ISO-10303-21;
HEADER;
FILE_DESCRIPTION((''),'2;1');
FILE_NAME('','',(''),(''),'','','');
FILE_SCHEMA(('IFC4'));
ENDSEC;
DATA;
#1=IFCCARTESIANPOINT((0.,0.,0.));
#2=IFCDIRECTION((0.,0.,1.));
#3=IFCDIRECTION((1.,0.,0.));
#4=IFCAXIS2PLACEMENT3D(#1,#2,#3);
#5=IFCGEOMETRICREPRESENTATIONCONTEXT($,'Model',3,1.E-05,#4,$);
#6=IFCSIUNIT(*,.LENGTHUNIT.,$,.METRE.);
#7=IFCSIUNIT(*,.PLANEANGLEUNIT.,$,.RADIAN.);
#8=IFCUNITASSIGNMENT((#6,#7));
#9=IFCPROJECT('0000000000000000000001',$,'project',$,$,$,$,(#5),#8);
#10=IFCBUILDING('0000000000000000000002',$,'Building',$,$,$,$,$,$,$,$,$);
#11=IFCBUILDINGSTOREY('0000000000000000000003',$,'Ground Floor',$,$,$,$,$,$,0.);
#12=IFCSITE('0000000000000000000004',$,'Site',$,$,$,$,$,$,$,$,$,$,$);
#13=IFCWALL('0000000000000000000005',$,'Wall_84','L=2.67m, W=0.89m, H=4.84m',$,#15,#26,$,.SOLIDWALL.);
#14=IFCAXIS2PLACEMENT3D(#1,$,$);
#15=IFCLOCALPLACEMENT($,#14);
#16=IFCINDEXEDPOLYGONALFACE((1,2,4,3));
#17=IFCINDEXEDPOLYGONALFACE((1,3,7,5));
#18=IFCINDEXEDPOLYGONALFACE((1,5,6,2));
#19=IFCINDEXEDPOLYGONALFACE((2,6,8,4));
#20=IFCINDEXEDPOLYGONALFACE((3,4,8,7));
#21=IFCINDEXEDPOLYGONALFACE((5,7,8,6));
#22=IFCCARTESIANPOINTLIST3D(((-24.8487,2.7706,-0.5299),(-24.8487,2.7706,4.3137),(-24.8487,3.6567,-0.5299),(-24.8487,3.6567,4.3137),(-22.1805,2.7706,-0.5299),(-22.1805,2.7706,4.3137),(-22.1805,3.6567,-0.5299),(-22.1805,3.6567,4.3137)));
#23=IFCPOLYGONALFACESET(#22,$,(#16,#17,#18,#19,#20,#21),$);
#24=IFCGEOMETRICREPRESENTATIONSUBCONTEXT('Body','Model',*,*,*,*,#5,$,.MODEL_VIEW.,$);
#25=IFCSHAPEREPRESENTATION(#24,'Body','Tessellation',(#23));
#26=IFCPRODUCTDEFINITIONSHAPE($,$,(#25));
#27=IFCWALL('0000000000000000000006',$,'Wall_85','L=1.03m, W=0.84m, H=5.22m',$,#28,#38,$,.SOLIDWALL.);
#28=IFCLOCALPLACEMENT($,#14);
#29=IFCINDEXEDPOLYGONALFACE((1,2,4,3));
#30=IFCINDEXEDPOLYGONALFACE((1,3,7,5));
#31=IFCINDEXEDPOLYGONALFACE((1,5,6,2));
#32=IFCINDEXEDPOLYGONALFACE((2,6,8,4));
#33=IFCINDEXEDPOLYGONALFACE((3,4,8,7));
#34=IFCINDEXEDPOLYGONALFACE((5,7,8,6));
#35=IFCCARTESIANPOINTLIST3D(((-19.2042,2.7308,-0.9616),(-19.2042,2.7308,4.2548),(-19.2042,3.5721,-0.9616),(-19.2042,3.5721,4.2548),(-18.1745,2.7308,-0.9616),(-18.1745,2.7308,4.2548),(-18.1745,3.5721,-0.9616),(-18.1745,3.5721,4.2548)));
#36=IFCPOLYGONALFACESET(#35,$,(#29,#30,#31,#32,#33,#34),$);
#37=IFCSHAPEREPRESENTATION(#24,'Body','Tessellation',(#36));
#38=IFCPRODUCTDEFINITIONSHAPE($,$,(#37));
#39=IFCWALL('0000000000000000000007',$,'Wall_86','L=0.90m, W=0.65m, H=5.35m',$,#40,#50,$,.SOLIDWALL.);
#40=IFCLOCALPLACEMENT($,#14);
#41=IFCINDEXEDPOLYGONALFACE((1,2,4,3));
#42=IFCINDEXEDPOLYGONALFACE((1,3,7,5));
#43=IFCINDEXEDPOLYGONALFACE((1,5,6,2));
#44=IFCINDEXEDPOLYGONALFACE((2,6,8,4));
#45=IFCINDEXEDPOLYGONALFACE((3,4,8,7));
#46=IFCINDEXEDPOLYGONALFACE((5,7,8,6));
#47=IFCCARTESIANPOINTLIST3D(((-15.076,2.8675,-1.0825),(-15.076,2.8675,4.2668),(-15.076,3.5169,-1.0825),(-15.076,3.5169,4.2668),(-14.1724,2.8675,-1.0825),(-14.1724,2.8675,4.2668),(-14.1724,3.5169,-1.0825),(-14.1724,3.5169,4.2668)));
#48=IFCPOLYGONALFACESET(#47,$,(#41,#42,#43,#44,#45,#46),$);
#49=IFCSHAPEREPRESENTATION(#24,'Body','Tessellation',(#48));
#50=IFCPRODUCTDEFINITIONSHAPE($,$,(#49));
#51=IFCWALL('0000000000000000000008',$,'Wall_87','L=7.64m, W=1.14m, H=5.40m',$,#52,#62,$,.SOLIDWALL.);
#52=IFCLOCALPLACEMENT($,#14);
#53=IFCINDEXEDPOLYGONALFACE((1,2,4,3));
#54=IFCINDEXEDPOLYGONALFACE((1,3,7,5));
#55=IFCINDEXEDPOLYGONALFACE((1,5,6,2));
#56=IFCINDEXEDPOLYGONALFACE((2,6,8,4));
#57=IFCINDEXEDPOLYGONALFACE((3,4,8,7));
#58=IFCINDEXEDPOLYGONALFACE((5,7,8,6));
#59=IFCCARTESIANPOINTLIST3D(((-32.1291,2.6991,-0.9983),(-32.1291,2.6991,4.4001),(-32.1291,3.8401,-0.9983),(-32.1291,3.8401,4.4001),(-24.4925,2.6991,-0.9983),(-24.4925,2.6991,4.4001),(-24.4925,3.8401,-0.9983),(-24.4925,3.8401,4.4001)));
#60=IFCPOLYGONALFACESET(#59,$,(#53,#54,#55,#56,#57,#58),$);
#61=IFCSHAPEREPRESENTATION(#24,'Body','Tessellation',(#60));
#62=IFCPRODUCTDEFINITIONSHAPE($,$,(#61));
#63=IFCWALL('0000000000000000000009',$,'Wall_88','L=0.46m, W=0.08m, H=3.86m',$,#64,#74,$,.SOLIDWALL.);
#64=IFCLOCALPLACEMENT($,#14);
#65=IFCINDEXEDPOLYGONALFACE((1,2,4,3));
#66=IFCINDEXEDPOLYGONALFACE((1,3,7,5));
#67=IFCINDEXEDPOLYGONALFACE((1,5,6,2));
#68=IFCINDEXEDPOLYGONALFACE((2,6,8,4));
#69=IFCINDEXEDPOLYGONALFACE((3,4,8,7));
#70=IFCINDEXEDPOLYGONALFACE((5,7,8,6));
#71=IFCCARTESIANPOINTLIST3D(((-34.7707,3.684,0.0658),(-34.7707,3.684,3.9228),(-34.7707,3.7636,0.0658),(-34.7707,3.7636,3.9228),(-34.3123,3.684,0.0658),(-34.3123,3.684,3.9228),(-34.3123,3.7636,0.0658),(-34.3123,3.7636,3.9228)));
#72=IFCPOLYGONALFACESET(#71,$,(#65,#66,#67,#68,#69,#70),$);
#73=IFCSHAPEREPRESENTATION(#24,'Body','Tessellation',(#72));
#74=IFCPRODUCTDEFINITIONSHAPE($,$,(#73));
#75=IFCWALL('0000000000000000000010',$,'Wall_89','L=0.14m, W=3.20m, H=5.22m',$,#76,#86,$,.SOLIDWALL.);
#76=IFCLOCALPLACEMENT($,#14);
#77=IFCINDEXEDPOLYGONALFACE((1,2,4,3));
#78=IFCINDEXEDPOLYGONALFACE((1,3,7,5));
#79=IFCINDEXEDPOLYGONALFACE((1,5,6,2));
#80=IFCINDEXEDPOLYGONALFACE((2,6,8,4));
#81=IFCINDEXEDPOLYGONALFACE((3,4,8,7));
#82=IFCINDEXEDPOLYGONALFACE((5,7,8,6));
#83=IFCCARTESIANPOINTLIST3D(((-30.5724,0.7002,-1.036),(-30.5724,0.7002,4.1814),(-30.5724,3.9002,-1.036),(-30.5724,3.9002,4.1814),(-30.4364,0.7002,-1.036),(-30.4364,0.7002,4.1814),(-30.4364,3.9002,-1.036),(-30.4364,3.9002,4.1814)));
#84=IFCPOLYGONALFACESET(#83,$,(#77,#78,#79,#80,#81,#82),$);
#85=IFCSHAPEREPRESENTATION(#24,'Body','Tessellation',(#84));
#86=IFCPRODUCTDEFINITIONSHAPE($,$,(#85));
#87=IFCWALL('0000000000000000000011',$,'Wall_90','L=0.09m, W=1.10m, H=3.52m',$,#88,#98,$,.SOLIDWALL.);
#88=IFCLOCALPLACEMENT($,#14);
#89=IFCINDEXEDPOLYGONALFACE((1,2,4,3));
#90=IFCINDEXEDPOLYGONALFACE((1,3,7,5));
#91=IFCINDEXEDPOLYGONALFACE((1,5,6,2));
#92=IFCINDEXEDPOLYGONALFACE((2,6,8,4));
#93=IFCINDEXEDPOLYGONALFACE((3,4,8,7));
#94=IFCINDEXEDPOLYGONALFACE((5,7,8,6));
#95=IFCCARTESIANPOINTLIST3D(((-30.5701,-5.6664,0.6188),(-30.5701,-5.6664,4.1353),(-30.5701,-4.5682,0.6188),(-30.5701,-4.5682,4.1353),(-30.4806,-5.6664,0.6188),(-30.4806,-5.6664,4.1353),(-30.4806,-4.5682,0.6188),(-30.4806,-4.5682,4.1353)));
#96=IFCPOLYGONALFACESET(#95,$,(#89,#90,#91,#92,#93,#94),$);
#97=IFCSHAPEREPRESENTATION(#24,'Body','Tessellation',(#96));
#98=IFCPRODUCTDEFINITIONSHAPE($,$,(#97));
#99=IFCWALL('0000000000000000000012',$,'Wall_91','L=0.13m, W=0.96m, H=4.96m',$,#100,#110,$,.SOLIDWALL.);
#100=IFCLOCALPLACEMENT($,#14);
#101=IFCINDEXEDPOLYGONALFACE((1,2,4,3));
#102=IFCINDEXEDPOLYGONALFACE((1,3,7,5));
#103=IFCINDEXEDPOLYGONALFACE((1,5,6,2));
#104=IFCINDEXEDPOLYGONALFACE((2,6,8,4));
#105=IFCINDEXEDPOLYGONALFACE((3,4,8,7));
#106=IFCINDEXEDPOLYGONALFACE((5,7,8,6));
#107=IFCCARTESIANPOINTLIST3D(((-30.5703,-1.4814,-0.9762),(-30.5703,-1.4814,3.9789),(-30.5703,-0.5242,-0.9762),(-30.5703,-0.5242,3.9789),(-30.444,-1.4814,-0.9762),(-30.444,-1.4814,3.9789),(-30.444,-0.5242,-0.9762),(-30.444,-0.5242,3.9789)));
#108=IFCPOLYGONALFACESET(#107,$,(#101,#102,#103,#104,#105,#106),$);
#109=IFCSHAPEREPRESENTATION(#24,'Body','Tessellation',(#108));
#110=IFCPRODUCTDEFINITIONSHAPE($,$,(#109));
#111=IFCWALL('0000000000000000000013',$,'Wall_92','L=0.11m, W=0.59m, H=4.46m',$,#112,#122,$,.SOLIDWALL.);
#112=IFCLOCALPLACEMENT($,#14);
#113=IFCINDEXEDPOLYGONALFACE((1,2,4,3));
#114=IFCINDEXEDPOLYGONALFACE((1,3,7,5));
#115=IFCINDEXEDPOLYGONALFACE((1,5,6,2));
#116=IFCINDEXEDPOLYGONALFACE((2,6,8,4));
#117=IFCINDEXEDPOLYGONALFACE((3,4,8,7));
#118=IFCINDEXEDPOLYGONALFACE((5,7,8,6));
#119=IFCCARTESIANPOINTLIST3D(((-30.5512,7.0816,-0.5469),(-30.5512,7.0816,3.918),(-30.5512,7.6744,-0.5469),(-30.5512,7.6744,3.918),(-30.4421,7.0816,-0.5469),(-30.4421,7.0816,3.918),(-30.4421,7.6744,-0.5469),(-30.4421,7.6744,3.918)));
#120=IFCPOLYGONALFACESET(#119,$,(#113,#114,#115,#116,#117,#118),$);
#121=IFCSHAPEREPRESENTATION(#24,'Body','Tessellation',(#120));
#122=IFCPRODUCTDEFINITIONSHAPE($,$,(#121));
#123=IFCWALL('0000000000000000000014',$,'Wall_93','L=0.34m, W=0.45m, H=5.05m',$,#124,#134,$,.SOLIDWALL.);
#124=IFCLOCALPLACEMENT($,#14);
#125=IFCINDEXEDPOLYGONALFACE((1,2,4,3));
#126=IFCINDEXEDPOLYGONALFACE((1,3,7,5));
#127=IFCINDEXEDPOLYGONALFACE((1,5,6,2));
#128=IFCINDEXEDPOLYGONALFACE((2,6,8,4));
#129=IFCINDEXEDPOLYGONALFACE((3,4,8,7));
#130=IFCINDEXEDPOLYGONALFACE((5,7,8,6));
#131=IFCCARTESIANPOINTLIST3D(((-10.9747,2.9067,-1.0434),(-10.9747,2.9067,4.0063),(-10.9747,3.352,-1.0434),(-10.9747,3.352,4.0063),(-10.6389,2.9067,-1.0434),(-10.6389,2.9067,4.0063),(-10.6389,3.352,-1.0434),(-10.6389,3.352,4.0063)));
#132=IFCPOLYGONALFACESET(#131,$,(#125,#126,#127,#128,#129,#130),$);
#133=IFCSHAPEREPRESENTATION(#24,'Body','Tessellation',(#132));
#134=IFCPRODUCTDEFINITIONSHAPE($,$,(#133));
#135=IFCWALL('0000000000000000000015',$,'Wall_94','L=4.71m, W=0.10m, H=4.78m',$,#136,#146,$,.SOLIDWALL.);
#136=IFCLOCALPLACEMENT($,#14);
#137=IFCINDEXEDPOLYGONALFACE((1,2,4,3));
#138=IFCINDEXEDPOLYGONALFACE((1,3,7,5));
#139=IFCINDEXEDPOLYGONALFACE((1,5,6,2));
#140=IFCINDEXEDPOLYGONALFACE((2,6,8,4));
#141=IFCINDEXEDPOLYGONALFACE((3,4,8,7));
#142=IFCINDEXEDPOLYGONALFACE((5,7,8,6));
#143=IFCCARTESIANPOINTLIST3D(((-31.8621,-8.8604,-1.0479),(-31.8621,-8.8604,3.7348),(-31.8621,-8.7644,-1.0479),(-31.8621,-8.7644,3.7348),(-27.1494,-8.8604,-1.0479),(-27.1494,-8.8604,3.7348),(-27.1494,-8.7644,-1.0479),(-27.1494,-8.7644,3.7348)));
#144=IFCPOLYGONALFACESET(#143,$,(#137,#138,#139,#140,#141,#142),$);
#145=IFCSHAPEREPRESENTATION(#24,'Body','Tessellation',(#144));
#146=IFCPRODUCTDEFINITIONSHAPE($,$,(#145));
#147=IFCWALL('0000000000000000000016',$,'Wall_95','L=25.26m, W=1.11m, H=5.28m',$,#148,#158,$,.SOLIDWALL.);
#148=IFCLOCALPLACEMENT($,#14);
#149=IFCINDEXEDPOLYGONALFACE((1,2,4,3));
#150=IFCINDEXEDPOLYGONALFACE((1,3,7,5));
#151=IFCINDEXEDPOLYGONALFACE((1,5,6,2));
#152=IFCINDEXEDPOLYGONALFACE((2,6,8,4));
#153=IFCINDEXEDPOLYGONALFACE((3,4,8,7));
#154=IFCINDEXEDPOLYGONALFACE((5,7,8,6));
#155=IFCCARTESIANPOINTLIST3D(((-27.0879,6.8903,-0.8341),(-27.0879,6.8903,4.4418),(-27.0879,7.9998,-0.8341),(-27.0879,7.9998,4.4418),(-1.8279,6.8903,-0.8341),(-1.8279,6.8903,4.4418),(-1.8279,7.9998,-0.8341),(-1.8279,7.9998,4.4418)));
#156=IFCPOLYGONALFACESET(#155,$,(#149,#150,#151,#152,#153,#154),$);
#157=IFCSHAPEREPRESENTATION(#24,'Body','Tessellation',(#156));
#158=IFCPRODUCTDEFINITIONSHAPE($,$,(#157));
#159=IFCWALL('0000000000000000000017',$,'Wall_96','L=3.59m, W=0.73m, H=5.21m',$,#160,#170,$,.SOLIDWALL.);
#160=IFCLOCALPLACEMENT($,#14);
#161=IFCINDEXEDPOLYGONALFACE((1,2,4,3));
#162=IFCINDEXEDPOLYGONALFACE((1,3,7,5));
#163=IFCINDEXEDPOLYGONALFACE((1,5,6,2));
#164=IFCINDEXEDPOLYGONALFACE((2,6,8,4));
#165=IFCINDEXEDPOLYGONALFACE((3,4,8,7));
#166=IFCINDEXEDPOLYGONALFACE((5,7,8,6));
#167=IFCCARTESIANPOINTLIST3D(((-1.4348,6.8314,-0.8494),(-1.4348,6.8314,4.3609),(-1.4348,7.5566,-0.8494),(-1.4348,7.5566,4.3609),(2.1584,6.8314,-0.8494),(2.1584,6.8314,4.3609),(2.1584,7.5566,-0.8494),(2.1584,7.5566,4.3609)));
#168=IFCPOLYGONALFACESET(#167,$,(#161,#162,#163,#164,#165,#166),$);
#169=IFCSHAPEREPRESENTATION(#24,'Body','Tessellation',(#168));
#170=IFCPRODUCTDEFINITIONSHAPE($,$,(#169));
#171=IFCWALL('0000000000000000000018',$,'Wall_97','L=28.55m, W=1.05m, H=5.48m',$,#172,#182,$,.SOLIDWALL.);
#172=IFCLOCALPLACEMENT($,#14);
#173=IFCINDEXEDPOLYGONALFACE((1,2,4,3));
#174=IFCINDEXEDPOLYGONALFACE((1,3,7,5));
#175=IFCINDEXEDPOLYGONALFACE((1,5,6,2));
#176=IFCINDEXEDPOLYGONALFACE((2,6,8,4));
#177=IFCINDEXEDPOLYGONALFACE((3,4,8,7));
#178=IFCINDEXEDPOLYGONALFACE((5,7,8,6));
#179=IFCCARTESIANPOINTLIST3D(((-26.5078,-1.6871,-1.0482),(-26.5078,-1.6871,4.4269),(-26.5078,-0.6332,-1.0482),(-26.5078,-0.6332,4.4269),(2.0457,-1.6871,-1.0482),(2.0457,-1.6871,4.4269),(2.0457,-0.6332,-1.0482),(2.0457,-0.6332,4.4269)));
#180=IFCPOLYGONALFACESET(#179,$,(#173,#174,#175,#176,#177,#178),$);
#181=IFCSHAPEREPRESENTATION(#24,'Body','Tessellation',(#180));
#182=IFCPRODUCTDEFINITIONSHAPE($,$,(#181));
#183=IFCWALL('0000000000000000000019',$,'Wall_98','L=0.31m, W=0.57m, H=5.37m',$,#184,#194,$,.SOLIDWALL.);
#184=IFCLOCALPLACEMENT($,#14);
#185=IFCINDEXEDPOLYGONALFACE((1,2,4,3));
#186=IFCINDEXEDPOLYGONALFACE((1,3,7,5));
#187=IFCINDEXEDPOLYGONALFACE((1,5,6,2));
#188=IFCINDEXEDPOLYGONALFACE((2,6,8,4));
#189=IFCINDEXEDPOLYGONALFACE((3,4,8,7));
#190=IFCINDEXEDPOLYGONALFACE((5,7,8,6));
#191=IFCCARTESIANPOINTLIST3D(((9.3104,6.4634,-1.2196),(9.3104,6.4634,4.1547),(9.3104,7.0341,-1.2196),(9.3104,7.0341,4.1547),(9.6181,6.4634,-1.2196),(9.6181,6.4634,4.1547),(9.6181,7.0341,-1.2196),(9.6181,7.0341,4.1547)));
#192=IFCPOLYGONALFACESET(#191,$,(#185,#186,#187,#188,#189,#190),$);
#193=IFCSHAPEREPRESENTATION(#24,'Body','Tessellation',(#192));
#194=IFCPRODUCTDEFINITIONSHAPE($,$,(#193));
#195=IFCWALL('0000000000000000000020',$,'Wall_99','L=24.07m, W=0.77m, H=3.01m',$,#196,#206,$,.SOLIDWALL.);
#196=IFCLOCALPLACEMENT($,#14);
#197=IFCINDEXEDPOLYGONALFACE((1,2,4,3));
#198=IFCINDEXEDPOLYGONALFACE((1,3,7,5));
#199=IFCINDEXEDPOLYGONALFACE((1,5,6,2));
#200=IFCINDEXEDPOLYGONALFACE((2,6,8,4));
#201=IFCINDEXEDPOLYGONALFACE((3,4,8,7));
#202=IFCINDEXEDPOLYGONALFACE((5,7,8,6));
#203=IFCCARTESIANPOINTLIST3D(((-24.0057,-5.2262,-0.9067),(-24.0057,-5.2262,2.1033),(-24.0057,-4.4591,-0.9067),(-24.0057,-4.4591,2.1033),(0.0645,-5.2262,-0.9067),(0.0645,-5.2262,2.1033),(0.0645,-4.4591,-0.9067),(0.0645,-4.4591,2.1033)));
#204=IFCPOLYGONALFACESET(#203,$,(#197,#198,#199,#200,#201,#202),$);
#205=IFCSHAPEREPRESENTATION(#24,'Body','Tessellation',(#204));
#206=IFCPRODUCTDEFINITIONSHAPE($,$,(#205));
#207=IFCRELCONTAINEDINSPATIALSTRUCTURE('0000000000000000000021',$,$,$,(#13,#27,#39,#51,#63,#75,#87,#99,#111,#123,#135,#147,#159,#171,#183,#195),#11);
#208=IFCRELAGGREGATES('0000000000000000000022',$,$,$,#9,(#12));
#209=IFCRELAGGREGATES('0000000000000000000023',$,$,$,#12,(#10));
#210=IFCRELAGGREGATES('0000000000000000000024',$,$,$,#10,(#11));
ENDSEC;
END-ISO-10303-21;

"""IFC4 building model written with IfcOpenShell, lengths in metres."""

from ifc_helpers import new_model, si_unit, frame, origin_with_axes, origin_2d, context, subcontext, project, spatial, rectangle, extrude, element, save


model = new_model("IFC4")

# Units and contexts
model_context = context("Model", 3, precision=1e-05, world=origin_with_axes())
body_context = subcontext(model_context, "Body", "Model", "MODEL_VIEW")
ifc_project = project(units=[si_unit("LENGTHUNIT", "METRE"), si_unit("PLANEANGLEUNIT", "RADIAN")], contexts=[model_context])

# Site, building, storey
site = spatial("IfcSite", under=ifc_project, Name="Site")
building = spatial("IfcBuilding", under=site, Name="Building")
storey = spatial("IfcBuildingStorey", under=building, Name="Ground Floor", Elevation=0.0)

# Walls
element("IfcWall", 1, inside=storey, Name="Wall_84", Description="L=2.67m, W=0.89m, H=4.84m", PredefinedType="SOLIDWALL", context=body_context, shape_type="SweptSolid", body=[
    extrude(rectangle(XDim=2.6682, YDim=0.8861, at=origin_2d()), frame((-23.5146, 3.2136, -0.5299), z_axis=(0.0, 0.0, 1.0), x_axis=(1.0, 0.0, 0.0)), (0.0, 0.0, 1.0), 4.8436),
])
element("IfcWall", 2, inside=storey, Name="Wall_85", Description="L=1.03m, W=0.84m, H=5.22m", PredefinedType="SOLIDWALL", context=body_context, shape_type="SweptSolid", body=[
    extrude(rectangle(XDim=1.0297, YDim=0.8412, at=origin_2d()), frame((-18.6894, 3.1514, -0.9616), z_axis=(0.0, 0.0, 1.0), x_axis=(1.0, 0.0, 0.0)), (0.0, 0.0, 1.0), 5.2164),
])
element("IfcWall", 3, inside=storey, Name="Wall_86", Description="L=0.90m, W=0.65m, H=5.35m", PredefinedType="SOLIDWALL", context=body_context, shape_type="SweptSolid", body=[
    extrude(rectangle(XDim=0.9035, YDim=0.6494, at=origin_2d()), frame((-14.6242, 3.1922, -1.0825), z_axis=(0.0, 0.0, 1.0), x_axis=(1.0, 0.0, 0.0)), (0.0, 0.0, 1.0), 5.3493),
])
element("IfcWall", 4, inside=storey, Name="Wall_87", Description="L=7.64m, W=1.14m, H=5.40m", PredefinedType="SOLIDWALL", context=body_context, shape_type="SweptSolid", body=[
    extrude(rectangle(XDim=7.6367, YDim=1.1411, at=origin_2d()), frame((-28.3108, 3.2696, -0.9983), z_axis=(0.0, 0.0, 1.0), x_axis=(1.0, 0.0, 0.0)), (0.0, 0.0, 1.0), 5.3984),
])
element("IfcWall", 5, inside=storey, Name="Wall_88", Description="L=0.46m, W=0.08m, H=3.86m", PredefinedType="SOLIDWALL", context=body_context, shape_type="SweptSolid", body=[
    extrude(rectangle(XDim=0.4584, YDim=0.0796, at=origin_2d()), frame((-34.5415, 3.7238, 0.0658), z_axis=(0.0, 0.0, 1.0), x_axis=(1.0, 0.0, 0.0)), (0.0, 0.0, 1.0), 3.857),
])
element("IfcWall", 6, inside=storey, Name="Wall_89", Description="L=0.14m, W=3.20m, H=5.22m", PredefinedType="SOLIDWALL", context=body_context, shape_type="SweptSolid", body=[
    extrude(rectangle(XDim=0.136, YDim=3.2, at=origin_2d()), frame((-30.5044, 2.3002, -1.036), z_axis=(0.0, 0.0, 1.0), x_axis=(1.0, 0.0, 0.0)), (0.0, 0.0, 1.0), 5.2174),
])
element("IfcWall", 7, inside=storey, Name="Wall_90", Description="L=0.09m, W=1.10m, H=3.52m", PredefinedType="SOLIDWALL", context=body_context, shape_type="SweptSolid", body=[
    extrude(rectangle(XDim=0.0895, YDim=1.0983, at=origin_2d()), frame((-30.5254, -5.1173, 0.6188), z_axis=(0.0, 0.0, 1.0), x_axis=(1.0, 0.0, 0.0)), (0.0, 0.0, 1.0), 3.5166),
])
element("IfcWall", 8, inside=storey, Name="Wall_91", Description="L=0.13m, W=0.96m, H=4.96m", PredefinedType="SOLIDWALL", context=body_context, shape_type="SweptSolid", body=[
    extrude(rectangle(XDim=0.1263, YDim=0.9571, at=origin_2d()), frame((-30.5071, -1.0028, -0.9762), z_axis=(0.0, 0.0, 1.0), x_axis=(1.0, 0.0, 0.0)), (0.0, 0.0, 1.0), 4.9551),
])
element("IfcWall", 9, inside=storey, Name="Wall_92", Description="L=0.11m, W=0.59m, H=4.46m", PredefinedType="SOLIDWALL", context=body_context, shape_type="SweptSolid", body=[
    extrude(rectangle(XDim=0.1091, YDim=0.5928, at=origin_2d()), frame((-30.4967, 7.378, -0.5469), z_axis=(0.0, 0.0, 1.0), x_axis=(1.0, 0.0, 0.0)), (0.0, 0.0, 1.0), 4.4649),
])
element("IfcWall", 10, inside=storey, Name="Wall_93", Description="L=0.34m, W=0.45m, H=5.05m", PredefinedType="SOLIDWALL", context=body_context, shape_type="SweptSolid", body=[
    extrude(rectangle(XDim=0.3358, YDim=0.4454, at=origin_2d()), frame((-10.8068, 3.1293, -1.0434), z_axis=(0.0, 0.0, 1.0), x_axis=(1.0, 0.0, 0.0)), (0.0, 0.0, 1.0), 5.0497),
])
element("IfcWall", 11, inside=storey, Name="Wall_94", Description="L=4.71m, W=0.10m, H=4.78m", PredefinedType="SOLIDWALL", context=body_context, shape_type="SweptSolid", body=[
    extrude(rectangle(XDim=4.7127, YDim=0.0959, at=origin_2d()), frame((-29.5058, -8.8124, -1.0479), z_axis=(0.0, 0.0, 1.0), x_axis=(1.0, 0.0, 0.0)), (0.0, 0.0, 1.0), 4.7827),
])
element("IfcWall", 12, inside=storey, Name="Wall_95", Description="L=25.26m, W=1.11m, H=5.28m", PredefinedType="SOLIDWALL", context=body_context, shape_type="SweptSolid", body=[
    extrude(rectangle(XDim=25.26, YDim=1.1095, at=origin_2d()), frame((-14.4579, 7.4451, -0.8341), z_axis=(0.0, 0.0, 1.0), x_axis=(1.0, 0.0, 0.0)), (0.0, 0.0, 1.0), 5.276),
])
element("IfcWall", 13, inside=storey, Name="Wall_96", Description="L=3.59m, W=0.73m, H=5.21m", PredefinedType="SOLIDWALL", context=body_context, shape_type="SweptSolid", body=[
    extrude(rectangle(XDim=3.5931, YDim=0.7253, at=origin_2d()), frame((0.3618, 7.194, -0.8494), z_axis=(0.0, 0.0, 1.0), x_axis=(1.0, 0.0, 0.0)), (0.0, 0.0, 1.0), 5.2103),
])
element("IfcWall", 14, inside=storey, Name="Wall_97", Description="L=28.55m, W=1.05m, H=5.48m", PredefinedType="SOLIDWALL", context=body_context, shape_type="SweptSolid", body=[
    extrude(rectangle(XDim=28.5534, YDim=1.0539, at=origin_2d()), frame((-12.231, -1.1601, -1.0482), z_axis=(0.0, 0.0, 1.0), x_axis=(1.0, 0.0, 0.0)), (0.0, 0.0, 1.0), 5.4752),
])
element("IfcWall", 15, inside=storey, Name="Wall_98", Description="L=0.31m, W=0.57m, H=5.37m", PredefinedType="SOLIDWALL", context=body_context, shape_type="SweptSolid", body=[
    extrude(rectangle(XDim=0.3077, YDim=0.5707, at=origin_2d()), frame((9.4642, 6.7487, -1.2196), z_axis=(0.0, 0.0, 1.0), x_axis=(1.0, 0.0, 0.0)), (0.0, 0.0, 1.0), 5.3743),
])
element("IfcWall", 16, inside=storey, Name="Wall_99", Description="L=24.07m, W=0.77m, H=3.01m", PredefinedType="SOLIDWALL", context=body_context, shape_type="SweptSolid", body=[
    extrude(rectangle(XDim=24.0702, YDim=0.7671, at=origin_2d()), frame((-11.9706, -4.8426, -0.9067), z_axis=(0.0, 0.0, 1.0), x_axis=(1.0, 0.0, 0.0)), (0.0, 0.0, 1.0), 3.01),
])

save(model, "model.ifc")
